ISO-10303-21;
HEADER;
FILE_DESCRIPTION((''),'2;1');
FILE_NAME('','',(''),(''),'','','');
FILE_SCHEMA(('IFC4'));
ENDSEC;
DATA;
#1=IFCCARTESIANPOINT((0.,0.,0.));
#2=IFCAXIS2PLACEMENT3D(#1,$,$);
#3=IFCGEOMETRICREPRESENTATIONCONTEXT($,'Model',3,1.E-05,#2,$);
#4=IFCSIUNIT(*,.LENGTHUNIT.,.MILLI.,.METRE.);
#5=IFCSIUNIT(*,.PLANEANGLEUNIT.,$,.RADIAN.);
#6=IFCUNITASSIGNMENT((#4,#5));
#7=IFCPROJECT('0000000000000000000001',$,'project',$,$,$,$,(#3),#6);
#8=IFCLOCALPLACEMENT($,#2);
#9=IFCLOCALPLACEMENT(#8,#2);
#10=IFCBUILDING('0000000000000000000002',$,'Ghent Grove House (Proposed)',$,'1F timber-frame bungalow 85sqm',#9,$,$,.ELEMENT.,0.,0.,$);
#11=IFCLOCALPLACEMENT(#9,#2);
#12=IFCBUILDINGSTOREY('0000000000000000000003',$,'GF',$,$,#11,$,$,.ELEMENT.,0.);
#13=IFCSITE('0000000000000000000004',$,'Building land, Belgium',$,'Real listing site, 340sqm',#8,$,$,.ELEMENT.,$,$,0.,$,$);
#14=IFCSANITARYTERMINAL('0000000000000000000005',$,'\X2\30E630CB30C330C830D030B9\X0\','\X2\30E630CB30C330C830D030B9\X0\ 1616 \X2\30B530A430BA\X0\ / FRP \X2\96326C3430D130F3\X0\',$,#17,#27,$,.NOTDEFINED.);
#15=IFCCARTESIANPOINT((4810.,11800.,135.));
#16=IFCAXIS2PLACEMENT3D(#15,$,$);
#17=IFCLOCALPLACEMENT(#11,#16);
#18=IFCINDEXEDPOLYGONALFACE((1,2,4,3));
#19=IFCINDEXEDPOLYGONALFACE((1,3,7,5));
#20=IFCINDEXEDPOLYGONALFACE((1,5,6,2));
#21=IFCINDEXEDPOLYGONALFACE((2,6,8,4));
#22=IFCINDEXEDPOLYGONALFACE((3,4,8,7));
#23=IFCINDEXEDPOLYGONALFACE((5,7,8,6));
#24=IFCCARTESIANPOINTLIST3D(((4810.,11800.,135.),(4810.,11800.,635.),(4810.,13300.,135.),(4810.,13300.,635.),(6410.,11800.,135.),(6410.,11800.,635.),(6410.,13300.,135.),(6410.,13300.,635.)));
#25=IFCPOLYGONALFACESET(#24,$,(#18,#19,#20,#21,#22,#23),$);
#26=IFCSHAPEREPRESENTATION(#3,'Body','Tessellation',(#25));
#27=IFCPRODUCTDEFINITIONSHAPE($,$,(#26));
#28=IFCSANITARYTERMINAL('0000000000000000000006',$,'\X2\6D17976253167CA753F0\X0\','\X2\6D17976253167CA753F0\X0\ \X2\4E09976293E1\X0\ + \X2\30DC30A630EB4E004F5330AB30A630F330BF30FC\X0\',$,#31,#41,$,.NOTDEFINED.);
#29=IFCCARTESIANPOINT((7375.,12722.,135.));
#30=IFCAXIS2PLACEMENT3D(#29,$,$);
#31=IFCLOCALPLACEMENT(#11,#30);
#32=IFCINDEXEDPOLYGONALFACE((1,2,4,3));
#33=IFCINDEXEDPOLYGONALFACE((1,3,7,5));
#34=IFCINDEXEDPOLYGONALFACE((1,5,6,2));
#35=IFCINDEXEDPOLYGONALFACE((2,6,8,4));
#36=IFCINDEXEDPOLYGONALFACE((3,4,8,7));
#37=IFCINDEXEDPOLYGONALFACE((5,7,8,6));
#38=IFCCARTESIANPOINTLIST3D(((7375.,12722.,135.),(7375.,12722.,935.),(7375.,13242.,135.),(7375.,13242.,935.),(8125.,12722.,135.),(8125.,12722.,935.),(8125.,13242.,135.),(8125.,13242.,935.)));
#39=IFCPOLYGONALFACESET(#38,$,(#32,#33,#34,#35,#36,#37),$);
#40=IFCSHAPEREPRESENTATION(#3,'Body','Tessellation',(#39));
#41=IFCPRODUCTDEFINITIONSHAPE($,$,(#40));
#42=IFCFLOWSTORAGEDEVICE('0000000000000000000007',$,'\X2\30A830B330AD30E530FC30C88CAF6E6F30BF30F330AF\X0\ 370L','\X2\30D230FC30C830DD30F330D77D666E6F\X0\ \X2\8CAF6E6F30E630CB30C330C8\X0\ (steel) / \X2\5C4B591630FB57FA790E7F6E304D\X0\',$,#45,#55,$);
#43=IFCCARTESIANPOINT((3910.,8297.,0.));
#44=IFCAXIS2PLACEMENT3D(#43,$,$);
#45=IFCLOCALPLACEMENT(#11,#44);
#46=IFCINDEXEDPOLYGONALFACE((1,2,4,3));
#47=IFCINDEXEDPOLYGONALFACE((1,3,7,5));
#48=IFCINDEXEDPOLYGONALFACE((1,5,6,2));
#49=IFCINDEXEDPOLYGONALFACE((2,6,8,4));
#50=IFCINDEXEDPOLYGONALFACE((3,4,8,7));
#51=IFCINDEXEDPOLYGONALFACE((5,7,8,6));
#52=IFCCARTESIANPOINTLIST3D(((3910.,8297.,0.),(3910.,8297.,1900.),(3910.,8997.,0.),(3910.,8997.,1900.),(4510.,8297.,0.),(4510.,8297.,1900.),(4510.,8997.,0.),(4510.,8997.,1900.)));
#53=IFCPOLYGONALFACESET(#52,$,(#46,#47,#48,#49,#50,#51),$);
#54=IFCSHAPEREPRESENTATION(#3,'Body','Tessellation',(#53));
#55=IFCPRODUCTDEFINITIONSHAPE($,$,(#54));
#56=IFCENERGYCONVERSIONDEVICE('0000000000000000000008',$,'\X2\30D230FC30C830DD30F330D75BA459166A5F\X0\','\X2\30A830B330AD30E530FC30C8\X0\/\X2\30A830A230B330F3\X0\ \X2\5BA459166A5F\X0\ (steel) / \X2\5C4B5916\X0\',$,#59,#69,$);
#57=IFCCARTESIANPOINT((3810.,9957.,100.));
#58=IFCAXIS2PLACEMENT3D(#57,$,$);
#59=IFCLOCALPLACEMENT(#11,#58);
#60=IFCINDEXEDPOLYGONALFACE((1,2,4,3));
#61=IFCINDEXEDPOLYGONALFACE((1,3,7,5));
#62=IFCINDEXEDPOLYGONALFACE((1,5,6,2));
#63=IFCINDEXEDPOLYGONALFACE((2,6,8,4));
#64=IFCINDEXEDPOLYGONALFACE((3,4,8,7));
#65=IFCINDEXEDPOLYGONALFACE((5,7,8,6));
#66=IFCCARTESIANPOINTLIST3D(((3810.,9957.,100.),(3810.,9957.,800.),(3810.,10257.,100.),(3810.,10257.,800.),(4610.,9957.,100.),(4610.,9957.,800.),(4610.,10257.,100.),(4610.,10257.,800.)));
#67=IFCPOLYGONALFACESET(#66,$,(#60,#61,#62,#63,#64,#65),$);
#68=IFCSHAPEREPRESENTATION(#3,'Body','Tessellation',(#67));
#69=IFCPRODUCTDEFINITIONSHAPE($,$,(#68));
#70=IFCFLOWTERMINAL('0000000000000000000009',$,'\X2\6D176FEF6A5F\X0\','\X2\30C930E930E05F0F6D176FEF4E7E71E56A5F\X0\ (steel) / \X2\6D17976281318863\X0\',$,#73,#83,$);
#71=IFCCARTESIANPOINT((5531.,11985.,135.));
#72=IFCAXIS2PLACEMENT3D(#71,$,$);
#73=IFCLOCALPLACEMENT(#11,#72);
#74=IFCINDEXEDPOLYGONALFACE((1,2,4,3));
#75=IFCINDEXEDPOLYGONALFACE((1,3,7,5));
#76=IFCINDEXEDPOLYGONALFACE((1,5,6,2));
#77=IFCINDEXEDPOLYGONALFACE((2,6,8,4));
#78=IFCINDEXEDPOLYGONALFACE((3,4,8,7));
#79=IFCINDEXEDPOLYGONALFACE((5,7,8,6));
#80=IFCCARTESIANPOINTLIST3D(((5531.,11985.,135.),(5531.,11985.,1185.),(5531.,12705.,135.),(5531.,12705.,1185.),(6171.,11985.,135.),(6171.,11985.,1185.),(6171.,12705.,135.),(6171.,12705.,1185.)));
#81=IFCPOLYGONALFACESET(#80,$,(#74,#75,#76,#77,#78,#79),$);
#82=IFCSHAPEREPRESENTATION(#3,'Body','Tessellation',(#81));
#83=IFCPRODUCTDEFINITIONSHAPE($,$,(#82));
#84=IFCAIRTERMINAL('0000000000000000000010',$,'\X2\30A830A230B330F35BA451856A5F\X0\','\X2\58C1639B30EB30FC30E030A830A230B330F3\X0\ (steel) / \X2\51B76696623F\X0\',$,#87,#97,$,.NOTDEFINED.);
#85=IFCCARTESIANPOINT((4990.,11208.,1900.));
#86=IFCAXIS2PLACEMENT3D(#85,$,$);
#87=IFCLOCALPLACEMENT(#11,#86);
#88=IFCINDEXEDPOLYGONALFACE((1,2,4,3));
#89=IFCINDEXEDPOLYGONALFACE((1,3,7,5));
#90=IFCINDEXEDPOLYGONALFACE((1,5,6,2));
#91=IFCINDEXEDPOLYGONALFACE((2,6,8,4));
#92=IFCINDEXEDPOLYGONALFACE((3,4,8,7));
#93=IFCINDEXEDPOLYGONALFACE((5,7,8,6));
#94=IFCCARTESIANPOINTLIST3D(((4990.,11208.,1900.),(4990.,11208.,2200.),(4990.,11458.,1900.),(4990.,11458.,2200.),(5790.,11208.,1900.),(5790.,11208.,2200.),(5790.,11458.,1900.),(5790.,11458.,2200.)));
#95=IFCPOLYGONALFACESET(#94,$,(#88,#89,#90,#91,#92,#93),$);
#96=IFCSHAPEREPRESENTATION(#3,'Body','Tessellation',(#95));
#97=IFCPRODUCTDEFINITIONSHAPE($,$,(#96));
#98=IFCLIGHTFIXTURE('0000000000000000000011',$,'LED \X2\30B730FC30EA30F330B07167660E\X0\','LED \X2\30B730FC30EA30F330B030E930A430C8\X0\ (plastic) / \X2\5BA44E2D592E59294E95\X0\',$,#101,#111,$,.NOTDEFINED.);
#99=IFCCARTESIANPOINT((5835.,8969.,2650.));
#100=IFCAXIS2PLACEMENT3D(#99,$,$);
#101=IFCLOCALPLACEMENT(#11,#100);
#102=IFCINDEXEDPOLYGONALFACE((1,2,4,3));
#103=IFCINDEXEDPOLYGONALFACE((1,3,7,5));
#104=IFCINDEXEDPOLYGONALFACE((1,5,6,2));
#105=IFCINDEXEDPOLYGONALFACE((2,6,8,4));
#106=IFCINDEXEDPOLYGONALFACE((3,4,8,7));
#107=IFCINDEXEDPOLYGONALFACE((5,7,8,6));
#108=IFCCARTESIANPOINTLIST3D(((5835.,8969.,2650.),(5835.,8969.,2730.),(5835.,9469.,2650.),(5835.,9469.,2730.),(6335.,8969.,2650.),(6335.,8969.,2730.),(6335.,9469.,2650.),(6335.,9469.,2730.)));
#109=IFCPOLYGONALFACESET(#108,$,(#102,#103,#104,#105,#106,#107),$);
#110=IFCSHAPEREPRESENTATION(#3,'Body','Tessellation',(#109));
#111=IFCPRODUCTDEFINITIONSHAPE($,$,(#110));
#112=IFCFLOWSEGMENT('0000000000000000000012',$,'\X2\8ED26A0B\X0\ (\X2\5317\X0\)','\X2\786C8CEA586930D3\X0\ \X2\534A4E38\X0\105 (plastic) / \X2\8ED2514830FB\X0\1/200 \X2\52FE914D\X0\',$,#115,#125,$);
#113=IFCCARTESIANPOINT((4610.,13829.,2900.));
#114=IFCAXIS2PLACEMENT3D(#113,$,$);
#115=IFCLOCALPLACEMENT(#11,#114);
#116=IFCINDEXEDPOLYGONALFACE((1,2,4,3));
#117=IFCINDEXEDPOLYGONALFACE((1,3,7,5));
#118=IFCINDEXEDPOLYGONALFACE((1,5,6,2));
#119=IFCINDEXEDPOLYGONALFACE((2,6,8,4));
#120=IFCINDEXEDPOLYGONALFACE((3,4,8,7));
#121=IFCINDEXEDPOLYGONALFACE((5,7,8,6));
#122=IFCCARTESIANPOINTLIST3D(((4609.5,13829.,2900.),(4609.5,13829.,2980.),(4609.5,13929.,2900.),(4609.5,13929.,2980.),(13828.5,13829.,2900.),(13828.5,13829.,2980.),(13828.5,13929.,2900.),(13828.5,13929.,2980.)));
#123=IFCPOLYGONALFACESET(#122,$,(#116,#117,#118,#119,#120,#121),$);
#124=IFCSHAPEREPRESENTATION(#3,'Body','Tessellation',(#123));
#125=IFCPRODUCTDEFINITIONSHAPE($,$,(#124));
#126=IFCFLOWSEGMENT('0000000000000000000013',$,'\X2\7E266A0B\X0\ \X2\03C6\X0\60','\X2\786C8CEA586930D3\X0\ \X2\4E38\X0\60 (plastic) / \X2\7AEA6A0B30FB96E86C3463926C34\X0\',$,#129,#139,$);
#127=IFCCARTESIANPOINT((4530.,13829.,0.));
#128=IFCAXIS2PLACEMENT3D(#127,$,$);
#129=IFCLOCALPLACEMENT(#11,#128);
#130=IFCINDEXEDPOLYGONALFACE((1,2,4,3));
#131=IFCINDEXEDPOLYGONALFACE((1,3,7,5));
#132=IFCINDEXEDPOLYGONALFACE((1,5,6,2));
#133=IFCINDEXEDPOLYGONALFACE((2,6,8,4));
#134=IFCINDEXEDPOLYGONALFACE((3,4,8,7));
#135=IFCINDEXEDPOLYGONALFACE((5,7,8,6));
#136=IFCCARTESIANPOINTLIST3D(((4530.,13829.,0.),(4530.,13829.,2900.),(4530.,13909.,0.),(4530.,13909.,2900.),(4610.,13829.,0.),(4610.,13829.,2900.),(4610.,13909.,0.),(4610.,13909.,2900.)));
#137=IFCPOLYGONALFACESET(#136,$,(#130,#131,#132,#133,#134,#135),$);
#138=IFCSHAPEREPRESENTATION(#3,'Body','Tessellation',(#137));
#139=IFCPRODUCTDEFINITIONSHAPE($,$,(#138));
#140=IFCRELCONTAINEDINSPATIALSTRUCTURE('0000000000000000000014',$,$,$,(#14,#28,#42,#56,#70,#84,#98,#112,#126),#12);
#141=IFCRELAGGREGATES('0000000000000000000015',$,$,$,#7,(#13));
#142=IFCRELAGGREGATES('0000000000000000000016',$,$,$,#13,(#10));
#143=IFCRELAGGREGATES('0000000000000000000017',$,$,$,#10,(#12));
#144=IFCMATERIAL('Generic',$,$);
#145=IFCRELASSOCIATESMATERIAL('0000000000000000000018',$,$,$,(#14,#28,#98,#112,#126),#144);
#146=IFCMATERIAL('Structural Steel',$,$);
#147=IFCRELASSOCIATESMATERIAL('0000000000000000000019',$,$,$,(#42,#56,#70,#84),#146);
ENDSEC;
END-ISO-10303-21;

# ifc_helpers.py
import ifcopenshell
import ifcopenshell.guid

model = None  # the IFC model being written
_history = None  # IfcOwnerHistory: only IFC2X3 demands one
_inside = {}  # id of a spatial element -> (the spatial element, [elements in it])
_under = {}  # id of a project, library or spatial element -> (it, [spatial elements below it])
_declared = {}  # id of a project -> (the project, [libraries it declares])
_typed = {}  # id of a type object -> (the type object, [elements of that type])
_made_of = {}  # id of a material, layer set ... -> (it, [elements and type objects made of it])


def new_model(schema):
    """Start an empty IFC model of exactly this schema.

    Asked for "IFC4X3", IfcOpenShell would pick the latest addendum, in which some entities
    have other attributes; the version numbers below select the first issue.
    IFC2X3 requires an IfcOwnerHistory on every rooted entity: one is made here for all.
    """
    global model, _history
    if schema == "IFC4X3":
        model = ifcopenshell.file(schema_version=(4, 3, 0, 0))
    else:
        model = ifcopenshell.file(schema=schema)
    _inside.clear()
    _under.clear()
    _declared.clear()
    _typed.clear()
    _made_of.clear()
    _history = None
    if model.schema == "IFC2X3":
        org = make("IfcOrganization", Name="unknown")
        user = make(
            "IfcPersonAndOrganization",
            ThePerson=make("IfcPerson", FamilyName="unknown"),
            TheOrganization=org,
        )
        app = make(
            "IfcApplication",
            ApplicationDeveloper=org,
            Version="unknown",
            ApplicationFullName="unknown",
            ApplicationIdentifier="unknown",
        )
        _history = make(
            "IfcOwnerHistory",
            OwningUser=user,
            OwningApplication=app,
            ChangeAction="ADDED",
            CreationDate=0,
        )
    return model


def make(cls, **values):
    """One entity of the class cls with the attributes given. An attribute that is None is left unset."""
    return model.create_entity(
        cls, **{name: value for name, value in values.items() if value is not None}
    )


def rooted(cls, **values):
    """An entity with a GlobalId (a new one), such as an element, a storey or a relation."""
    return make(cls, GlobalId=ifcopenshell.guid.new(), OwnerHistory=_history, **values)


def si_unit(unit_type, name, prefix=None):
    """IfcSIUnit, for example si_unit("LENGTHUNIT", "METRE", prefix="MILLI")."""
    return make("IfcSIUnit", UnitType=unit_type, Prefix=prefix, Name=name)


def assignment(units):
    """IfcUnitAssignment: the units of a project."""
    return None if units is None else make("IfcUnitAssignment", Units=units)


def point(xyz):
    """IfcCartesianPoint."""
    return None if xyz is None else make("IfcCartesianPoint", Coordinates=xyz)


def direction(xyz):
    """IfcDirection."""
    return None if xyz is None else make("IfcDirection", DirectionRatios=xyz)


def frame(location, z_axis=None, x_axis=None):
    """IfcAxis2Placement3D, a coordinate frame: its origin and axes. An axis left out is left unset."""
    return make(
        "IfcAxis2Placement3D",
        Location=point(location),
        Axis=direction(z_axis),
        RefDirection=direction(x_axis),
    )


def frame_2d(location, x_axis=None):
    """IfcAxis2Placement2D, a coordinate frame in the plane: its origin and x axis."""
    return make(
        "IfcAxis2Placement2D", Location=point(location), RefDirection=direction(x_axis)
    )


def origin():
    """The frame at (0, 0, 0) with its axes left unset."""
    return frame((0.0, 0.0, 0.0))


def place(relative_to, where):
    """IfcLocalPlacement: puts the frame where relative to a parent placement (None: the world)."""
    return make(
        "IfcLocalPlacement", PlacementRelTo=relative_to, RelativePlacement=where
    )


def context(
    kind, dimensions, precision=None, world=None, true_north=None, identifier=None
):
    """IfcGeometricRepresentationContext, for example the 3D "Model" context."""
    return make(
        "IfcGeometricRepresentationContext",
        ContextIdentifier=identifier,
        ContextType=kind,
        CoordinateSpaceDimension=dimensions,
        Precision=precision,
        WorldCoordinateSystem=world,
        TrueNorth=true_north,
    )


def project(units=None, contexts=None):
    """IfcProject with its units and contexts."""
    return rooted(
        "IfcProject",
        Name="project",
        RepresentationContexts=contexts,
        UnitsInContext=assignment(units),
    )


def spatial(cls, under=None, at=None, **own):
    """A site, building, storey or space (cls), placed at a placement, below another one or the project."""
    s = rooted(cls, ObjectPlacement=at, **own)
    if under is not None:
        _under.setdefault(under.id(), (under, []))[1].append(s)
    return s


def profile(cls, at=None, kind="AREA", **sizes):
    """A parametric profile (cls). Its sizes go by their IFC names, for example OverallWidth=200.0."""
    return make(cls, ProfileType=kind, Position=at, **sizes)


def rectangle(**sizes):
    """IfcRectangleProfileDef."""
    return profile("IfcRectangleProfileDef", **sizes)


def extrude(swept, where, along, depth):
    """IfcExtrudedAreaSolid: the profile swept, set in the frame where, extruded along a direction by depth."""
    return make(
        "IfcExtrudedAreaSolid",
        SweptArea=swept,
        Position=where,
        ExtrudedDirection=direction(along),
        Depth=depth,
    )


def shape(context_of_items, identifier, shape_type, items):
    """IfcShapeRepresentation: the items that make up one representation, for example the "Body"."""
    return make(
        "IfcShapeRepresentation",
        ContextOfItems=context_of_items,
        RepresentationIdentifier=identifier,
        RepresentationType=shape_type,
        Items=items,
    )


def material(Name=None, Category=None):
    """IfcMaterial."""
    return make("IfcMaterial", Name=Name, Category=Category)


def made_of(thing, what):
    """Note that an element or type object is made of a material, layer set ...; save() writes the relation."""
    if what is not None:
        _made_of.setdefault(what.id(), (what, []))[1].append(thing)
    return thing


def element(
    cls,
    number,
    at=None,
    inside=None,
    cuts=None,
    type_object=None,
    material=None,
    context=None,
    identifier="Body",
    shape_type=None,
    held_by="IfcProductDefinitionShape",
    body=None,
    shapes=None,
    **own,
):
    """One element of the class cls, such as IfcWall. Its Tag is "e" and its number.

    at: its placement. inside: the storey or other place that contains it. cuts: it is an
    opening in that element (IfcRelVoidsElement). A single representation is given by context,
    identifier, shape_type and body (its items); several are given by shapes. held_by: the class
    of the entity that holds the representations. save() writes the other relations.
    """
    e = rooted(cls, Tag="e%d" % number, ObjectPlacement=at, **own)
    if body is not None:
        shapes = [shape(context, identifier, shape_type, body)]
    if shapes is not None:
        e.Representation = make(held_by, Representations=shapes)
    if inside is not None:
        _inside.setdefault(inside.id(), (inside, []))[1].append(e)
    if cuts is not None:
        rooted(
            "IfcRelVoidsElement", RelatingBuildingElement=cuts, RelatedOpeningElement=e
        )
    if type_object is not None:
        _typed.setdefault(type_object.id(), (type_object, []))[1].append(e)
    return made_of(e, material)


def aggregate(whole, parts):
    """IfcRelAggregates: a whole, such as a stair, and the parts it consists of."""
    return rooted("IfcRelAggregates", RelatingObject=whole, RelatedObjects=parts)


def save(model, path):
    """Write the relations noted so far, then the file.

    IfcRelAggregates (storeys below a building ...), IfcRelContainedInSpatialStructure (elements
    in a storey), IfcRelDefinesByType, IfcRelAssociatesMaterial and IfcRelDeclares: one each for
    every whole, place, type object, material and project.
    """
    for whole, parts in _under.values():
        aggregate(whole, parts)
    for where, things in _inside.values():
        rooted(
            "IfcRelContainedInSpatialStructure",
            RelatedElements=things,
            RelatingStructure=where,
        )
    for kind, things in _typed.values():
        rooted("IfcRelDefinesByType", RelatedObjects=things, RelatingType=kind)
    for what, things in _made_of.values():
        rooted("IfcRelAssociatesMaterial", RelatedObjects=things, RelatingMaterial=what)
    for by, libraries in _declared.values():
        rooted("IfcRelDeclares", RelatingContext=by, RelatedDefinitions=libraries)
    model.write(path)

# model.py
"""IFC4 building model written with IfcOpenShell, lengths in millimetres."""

from ifc_helpers import new_model, si_unit, frame, frame_2d, origin, place, context, project, spatial, rectangle, extrude, material, element, save


model = new_model("IFC4")

# Units and contexts
model_context = context("Model", 3, precision=1e-05, world=origin())
ifc_project = project(units=[si_unit("LENGTHUNIT", "METRE", prefix="MILLI"), si_unit("PLANEANGLEUNIT", "RADIAN")], contexts=[model_context])

# Site, building, storey
site_placement = place(None, origin())
site = spatial("IfcSite", under=ifc_project, at=site_placement, Name="Building land, Belgium", ObjectType="Real listing site, 340sqm", CompositionType="ELEMENT", RefElevation=0.0)
building_placement = place(site_placement, origin())
building = spatial("IfcBuilding", under=site, at=building_placement, Name="Ghent Grove House (Proposed)", ObjectType="1F timber-frame bungalow 85sqm", CompositionType="ELEMENT", ElevationOfRefHeight=0.0, ElevationOfTerrain=0.0)
storey_placement = place(building_placement, origin())
storey = spatial("IfcBuildingStorey", under=building, at=storey_placement, Name="GF", CompositionType="ELEMENT", Elevation=0.0)

# Shared definitions
ifc_material_1 = material(Name="Structural Steel")

# Shared definitions
ifc_material_2 = material(Name="Generic")

# Sanitary terminals
sanitary_terminal_1_placement = place(storey_placement, frame((4810.0, 11800.0, 135.0)))
element("IfcSanitaryTerminal", 1, at=sanitary_terminal_1_placement, inside=storey, material=ifc_material_2, Name="ユニットバス", Description="ユニットバス 1616 サイズ / FRP 防水パン", PredefinedType="NOTDEFINED", context=model_context, shape_type="SweptSolid", body=[
    extrude(rectangle(XDim=1600.0, YDim=1500.0, at=frame_2d((800.0, 750.0))), frame((4810.0, 11800.0, 135.0)), (0.0, 0.0, 1.0), 500.0),
])
sanitary_terminal_2_placement = place(storey_placement, frame((7375.0, 12722.0, 135.0)))
element("IfcSanitaryTerminal", 2, at=sanitary_terminal_2_placement, inside=storey, material=ifc_material_2, Name="洗面化粧台", Description="洗面化粧台 三面鏡 + ボウル一体カウンター", PredefinedType="NOTDEFINED", context=model_context, shape_type="SweptSolid", body=[
    extrude(rectangle(XDim=750.0, YDim=520.0, at=frame_2d((375.0, 260.0))), frame((7375.0, 12722.0, 135.0)), (0.0, 0.0, 1.0), 800.0),
])

# Flow storage device
flow_storage_device_placement = place(storey_placement, frame((3910.0, 8297.0, 0.0)))
element("IfcFlowStorageDevice", 3, at=flow_storage_device_placement, inside=storey, material=ifc_material_1, Name="エコキュート貯湯タンク 370L", Description="ヒートポンプ給湯 貯湯ユニット (steel) / 屋外・基礎置き", context=model_context, shape_type="SweptSolid", body=[
    extrude(rectangle(XDim=600.0, YDim=700.0, at=frame_2d((300.0, 350.0))), frame((3910.0, 8297.0, 0.0)), (0.0, 0.0, 1.0), 1900.0),
])

# Energy conversion device
energy_conversion_device_placement = place(storey_placement, frame((3810.0, 9957.0, 100.0)))
element("IfcEnergyConversionDevice", 4, at=energy_conversion_device_placement, inside=storey, material=ifc_material_1, Name="ヒートポンプ室外機", Description="エコキュート/エアコン 室外機 (steel) / 屋外", context=model_context, shape_type="SweptSolid", body=[
    extrude(rectangle(XDim=800.0, YDim=300.0, at=frame_2d((400.0, 150.0))), frame((3810.0, 9957.0, 100.0)), (0.0, 0.0, 1.0), 700.0),
])

# Flow terminal
flow_terminal_placement = place(storey_placement, frame((5531.0, 11985.0, 135.0)))
element("IfcFlowTerminal", 5, at=flow_terminal_placement, inside=storey, material=ifc_material_1, Name="洗濯機", Description="ドラム式洗濯乾燥機 (steel) / 洗面脱衣", context=model_context, shape_type="SweptSolid", body=[
    extrude(rectangle(XDim=640.0, YDim=720.0, at=frame_2d((320.0, 360.0))), frame((5531.0, 11985.0, 135.0)), (0.0, 0.0, 1.0), 1050.0),
])

# Air terminal
air_terminal_placement = place(storey_placement, frame((4990.0, 11208.0, 1900.0)))
element("IfcAirTerminal", 6, at=air_terminal_placement, inside=storey, material=ifc_material_1, Name="エアコン室内機", Description="壁掛ルームエアコン (steel) / 冷暖房", PredefinedType="NOTDEFINED", context=model_context, shape_type="SweptSolid", body=[
    extrude(rectangle(XDim=800.0, YDim=250.0, at=frame_2d((400.0, 125.0))), frame((4990.0, 11208.0, 1900.0)), (0.0, 0.0, 1.0), 300.0),
])

# Light fixture
light_fixture_placement = place(storey_placement, frame((5835.0, 8969.0, 2650.0)))
element("IfcLightFixture", 7, at=light_fixture_placement, inside=storey, material=ifc_material_2, Name="LED シーリング照明", Description="LED シーリングライト (plastic) / 室中央天井", PredefinedType="NOTDEFINED", context=model_context, shape_type="SweptSolid", body=[
    extrude(rectangle(XDim=500.0, YDim=500.0, at=frame_2d((250.0, 250.0))), frame((5835.0, 8969.0, 2650.0)), (0.0, 0.0, 1.0), 80.0),
])

# Flow segments
flow_segment_1_placement = place(storey_placement, frame((4610.0, 13829.0, 2900.0)))
element("IfcFlowSegment", 8, at=flow_segment_1_placement, inside=storey, material=ifc_material_2, Name="軒樋 (北)", Description="硬質塩ビ 半丸105 (plastic) / 軒先・1/200 勾配", context=model_context, shape_type="SweptSolid", body=[
    extrude(rectangle(XDim=9219.0, YDim=100.0, at=frame_2d((4609.0, 50.0))), frame((4610.0, 13829.0, 2900.0)), (0.0, 0.0, 1.0), 80.0),
])
flow_segment_2_placement = place(storey_placement, frame((4530.0, 13829.0, 0.0)))
element("IfcFlowSegment", 9, at=flow_segment_2_placement, inside=storey, material=ifc_material_2, Name="縦樋 φ60", Description="硬質塩ビ 丸60 (plastic) / 竪樋・雨水排水", context=model_context, shape_type="SweptSolid", body=[
    extrude(rectangle(XDim=80.0, YDim=80.0, at=frame_2d((40.0, 40.0))), frame((4530.0, 13829.0, 0.0)), (0.0, 0.0, 1.0), 2900.0),
])

save(model, "model.ifc")
